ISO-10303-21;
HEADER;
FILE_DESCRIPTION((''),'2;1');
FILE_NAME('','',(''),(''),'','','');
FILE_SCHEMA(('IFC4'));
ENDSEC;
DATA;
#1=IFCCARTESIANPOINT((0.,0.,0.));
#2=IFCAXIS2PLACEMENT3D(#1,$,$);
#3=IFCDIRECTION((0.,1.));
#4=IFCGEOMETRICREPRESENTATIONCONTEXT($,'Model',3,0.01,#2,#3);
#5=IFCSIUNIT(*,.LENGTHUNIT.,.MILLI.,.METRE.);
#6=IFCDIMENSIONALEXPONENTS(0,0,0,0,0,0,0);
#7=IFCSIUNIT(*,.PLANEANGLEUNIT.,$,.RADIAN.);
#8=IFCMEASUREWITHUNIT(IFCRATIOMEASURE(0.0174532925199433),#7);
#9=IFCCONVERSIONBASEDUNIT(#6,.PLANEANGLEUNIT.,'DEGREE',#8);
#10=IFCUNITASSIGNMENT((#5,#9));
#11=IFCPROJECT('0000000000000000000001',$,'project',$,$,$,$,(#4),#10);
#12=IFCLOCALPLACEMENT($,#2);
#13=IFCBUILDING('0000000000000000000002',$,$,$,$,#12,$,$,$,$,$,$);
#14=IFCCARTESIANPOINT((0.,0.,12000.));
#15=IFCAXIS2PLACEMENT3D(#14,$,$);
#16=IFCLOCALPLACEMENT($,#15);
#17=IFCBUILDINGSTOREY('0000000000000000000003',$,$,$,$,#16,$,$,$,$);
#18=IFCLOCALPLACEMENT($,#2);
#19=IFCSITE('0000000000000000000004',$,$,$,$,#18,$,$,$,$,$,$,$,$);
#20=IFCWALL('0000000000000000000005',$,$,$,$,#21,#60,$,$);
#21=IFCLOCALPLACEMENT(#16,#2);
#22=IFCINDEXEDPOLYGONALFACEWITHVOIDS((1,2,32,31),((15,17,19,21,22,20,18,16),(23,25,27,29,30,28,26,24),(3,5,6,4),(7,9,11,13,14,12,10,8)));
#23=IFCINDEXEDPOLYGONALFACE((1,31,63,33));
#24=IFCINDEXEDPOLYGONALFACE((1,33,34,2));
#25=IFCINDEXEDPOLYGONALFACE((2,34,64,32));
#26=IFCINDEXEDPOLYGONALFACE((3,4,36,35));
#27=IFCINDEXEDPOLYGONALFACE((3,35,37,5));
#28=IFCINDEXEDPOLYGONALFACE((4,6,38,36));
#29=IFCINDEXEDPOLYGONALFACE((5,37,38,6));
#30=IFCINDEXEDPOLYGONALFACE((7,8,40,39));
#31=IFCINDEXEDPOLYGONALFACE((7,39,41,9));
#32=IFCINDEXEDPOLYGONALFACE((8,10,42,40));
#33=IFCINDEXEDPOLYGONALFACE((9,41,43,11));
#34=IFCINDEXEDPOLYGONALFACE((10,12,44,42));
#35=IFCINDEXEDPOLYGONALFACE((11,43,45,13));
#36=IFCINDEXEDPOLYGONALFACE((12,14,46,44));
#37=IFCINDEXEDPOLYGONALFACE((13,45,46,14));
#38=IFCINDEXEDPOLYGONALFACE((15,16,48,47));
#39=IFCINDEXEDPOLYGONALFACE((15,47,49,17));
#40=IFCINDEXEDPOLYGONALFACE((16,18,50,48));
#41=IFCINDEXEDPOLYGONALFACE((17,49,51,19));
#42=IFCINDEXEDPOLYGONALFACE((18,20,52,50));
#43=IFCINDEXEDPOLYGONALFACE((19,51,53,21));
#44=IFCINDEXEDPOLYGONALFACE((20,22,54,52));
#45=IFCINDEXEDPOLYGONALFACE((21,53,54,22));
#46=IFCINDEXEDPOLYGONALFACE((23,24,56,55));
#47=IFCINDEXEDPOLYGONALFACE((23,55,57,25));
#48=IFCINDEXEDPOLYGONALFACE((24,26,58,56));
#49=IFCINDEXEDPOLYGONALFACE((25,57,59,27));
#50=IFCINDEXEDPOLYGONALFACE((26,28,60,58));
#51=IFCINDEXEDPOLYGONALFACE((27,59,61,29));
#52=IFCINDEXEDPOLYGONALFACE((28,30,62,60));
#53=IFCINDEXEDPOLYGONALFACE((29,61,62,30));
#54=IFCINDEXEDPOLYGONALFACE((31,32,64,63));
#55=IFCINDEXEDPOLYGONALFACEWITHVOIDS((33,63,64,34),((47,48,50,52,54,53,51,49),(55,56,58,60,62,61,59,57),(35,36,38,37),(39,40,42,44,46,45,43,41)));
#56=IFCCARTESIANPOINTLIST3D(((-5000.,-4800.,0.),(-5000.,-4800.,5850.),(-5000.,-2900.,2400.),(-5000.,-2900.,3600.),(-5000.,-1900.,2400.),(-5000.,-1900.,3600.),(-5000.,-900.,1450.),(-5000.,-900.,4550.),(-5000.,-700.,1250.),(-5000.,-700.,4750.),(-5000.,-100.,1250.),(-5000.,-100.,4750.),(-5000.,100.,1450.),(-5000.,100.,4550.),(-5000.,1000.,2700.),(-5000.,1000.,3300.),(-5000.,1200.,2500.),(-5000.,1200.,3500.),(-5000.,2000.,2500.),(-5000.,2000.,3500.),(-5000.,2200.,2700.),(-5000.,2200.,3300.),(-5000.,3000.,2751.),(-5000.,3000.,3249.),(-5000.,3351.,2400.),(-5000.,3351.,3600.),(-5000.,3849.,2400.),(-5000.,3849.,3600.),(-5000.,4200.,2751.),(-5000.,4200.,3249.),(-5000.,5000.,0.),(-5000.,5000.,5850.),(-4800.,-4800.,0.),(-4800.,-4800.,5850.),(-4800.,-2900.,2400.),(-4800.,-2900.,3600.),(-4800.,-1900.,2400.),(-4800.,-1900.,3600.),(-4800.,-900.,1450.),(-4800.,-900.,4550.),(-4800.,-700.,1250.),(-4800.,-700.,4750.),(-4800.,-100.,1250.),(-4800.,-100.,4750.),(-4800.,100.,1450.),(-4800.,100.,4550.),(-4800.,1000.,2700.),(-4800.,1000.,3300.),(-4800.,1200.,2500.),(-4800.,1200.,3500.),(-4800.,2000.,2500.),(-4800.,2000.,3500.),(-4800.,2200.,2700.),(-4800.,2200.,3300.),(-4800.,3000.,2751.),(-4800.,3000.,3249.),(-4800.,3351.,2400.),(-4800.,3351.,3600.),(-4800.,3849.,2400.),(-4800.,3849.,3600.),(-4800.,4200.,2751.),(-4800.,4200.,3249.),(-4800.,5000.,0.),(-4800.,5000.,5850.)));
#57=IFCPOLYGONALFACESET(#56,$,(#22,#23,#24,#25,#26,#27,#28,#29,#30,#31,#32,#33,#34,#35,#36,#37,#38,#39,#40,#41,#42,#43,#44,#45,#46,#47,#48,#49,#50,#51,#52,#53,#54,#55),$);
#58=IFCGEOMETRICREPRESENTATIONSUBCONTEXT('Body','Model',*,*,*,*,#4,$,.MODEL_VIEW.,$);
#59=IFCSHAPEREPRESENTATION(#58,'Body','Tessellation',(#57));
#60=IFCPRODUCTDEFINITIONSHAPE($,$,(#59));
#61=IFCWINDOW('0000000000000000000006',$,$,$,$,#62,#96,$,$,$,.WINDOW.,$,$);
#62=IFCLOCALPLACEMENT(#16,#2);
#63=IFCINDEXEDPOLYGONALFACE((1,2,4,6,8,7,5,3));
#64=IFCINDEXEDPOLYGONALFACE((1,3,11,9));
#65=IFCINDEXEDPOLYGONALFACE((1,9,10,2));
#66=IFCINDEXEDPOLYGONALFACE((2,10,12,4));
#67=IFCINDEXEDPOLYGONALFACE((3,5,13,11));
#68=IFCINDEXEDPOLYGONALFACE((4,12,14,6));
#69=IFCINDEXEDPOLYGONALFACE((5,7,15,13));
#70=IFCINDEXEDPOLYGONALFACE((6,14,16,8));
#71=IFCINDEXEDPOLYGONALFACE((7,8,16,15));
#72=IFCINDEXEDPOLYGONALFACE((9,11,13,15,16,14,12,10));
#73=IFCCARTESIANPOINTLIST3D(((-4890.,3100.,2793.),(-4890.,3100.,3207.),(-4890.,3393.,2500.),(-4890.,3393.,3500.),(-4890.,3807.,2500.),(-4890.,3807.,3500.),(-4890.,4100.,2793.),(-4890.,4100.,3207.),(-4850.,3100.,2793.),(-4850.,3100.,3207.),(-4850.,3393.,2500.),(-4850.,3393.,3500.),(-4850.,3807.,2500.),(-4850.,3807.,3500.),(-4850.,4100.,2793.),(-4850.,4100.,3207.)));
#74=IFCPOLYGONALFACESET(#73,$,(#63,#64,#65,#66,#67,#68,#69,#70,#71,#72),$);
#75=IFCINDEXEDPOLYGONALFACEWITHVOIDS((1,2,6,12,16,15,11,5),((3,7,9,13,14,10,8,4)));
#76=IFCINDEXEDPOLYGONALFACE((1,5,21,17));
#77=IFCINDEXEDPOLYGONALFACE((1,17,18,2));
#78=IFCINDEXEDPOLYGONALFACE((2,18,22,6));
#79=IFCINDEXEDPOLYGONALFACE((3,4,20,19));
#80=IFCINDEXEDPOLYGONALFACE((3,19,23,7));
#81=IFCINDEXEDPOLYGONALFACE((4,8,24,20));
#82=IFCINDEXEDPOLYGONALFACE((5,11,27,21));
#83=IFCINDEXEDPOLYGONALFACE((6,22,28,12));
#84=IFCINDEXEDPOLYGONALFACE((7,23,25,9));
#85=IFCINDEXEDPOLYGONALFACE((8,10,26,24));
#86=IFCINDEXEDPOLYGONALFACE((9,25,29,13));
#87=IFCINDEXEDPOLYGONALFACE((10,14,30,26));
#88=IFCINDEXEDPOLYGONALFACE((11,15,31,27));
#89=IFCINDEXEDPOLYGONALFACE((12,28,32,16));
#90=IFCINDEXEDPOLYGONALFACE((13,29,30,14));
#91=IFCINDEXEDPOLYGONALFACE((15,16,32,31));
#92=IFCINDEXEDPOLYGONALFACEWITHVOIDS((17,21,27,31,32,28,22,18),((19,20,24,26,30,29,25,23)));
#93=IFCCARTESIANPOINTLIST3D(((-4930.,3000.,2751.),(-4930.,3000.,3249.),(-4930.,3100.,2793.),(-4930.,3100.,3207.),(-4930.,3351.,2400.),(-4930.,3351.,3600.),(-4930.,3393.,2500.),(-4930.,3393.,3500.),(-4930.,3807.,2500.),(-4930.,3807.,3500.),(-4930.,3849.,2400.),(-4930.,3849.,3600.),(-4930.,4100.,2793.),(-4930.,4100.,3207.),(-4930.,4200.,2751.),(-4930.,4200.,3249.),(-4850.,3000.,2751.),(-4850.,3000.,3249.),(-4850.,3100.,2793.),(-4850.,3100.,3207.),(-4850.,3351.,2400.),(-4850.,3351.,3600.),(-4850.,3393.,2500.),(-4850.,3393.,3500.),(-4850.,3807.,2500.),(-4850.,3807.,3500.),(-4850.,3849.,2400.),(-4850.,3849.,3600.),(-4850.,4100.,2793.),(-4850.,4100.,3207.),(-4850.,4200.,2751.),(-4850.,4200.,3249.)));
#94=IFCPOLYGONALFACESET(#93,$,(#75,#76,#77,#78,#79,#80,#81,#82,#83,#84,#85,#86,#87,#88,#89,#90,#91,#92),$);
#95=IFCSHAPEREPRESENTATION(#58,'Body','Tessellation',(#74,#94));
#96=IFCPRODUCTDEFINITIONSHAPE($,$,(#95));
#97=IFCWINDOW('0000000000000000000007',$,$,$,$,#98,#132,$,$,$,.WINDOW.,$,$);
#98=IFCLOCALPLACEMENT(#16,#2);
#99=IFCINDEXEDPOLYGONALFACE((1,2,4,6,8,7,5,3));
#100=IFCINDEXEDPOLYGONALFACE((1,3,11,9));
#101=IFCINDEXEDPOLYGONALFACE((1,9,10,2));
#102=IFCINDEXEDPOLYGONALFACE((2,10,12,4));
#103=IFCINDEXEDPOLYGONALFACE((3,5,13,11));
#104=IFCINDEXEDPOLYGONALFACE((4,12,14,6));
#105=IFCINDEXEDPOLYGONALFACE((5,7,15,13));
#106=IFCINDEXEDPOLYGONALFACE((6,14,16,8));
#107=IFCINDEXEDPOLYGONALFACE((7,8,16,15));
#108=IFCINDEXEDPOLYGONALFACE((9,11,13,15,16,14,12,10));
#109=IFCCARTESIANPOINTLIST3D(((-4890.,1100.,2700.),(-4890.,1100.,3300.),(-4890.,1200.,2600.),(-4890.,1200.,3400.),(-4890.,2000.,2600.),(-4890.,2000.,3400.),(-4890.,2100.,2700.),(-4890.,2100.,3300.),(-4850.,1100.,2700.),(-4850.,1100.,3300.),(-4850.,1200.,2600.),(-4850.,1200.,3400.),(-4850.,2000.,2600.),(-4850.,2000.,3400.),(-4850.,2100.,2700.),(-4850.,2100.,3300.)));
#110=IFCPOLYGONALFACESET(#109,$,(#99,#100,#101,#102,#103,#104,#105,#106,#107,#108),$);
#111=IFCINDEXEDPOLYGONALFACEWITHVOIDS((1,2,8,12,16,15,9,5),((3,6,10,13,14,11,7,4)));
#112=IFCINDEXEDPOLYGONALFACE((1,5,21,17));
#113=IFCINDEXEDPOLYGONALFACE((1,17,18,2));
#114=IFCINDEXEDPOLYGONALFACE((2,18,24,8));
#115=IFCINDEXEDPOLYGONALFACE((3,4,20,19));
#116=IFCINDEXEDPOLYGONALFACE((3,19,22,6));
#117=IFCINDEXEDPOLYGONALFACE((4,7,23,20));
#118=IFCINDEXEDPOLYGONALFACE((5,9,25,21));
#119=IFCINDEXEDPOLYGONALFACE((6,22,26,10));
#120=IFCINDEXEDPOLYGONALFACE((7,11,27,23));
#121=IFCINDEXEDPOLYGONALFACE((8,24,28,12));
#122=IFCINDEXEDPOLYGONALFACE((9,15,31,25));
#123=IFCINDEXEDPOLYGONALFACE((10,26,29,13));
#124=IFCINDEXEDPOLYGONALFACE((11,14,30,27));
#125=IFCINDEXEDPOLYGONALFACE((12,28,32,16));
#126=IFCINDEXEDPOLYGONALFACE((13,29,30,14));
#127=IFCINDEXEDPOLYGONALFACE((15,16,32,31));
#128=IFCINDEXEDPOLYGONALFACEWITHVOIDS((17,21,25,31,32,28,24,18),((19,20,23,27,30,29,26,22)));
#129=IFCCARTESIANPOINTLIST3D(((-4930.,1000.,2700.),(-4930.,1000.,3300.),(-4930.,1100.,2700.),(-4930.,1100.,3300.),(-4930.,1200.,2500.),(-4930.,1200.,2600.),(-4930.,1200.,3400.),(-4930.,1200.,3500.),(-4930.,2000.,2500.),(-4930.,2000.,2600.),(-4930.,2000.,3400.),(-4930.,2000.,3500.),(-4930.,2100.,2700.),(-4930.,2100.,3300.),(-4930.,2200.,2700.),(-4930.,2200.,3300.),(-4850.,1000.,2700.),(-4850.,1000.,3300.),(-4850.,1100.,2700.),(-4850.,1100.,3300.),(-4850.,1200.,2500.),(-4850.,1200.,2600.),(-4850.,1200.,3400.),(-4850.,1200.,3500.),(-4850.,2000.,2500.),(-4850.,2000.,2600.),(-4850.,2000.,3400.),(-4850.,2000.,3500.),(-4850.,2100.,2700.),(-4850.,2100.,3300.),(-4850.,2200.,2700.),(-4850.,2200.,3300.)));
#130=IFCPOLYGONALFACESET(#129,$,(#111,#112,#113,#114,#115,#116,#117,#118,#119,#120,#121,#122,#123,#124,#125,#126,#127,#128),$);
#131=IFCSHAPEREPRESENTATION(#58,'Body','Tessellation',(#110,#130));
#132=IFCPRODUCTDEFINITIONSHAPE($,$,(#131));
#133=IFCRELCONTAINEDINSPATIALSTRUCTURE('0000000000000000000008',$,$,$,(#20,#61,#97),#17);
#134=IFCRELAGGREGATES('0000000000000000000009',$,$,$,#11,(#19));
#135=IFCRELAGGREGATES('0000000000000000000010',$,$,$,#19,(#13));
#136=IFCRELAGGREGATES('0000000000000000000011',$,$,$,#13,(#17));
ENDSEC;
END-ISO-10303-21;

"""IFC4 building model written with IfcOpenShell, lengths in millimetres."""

from ifc_helpers import new_model, entity, si_unit, converted_unit, direction, frame, origin, origin_2d, place, context, subcontext, project, spatial, polyline, rectangle, outline, extrude, element, save


model = new_model("IFC4")

# Units and contexts
model_context = context("Model", 3, precision=0.01, world=origin(), true_north=direction((0.0, 1.0)))
body_context = subcontext(model_context, "Body", "Model", "MODEL_VIEW")
ifc_project = project(units=[si_unit("LENGTHUNIT", "METRE", prefix="MILLI"), converted_unit("PLANEANGLEUNIT", "DEGREE", entity("IfcRatioMeasure", 0.0174532925199433), si_unit("PLANEANGLEUNIT", "RADIAN"), dimensions=[0, 0, 0, 0, 0, 0, 0])], contexts=[model_context])

# Site, building, storey
site_placement = place(None, origin())
site = spatial("IfcSite", under=ifc_project, at=site_placement)
building_placement = place(None, origin())
building = spatial("IfcBuilding", under=site, at=building_placement)
storey_placement = place(None, frame((0.0, 0.0, 12000.0)))
storey = spatial("IfcBuildingStorey", under=building, at=storey_placement)

# Shared definitions
cartesian_point_1 = entity("IfcCartesianPoint", [-500.0, -207.0])
shared_polyline_1 = entity("IfcPolyline", [cartesian_point_1, entity("IfcCartesianPoint", [-500.0, 207.0]), entity("IfcCartesianPoint", [-207.0, 500.0]), entity("IfcCartesianPoint", [207.0, 500.0]), entity("IfcCartesianPoint", [500.0, 207.0]), entity("IfcCartesianPoint", [500.0, -207.0]), entity("IfcCartesianPoint", [207.0, -500.0]), entity("IfcCartesianPoint", [-207.0, -500.0]), cartesian_point_1])
cartesian_point_2 = entity("IfcCartesianPoint", [-500.0, -300.0])
shared_polyline_2 = entity("IfcPolyline", [cartesian_point_2, entity("IfcCartesianPoint", [-500.0, 300.0]), entity("IfcCartesianPoint", [-400.0, 400.0]), entity("IfcCartesianPoint", [400.0, 400.0]), entity("IfcCartesianPoint", [500.0, 300.0]), entity("IfcCartesianPoint", [500.0, -300.0]), entity("IfcCartesianPoint", [400.0, -400.0]), entity("IfcCartesianPoint", [-400.0, -400.0]), cartesian_point_2])

# Wall, openings
wall_1_placement = place(storey_placement, frame((-4900.0, 100.0, 0.0), z_axis=(0.0, 0.0, 1.0), x_axis=(0.0, -1.0, 0.0)))
wall_1 = element("IfcWall", 1, at=wall_1_placement, inside=storey, context=body_context, shape_type="SweptSolid", body=[
    extrude(rectangle(XDim=9800.0, YDim=200.0, at=origin_2d()), origin(), (0.0, 0.0, 1.0), 5850.0),
])
window_1_placement = place(wall_1_placement, frame((-3500.0, 50.0, 3000.0)))
opening_1_placement = place(window_1_placement, frame((0.0, 50.0, 0.0)))
element("IfcOpeningElement", 2, at=opening_1_placement, cuts=wall_1, context=body_context, shape_type="SweptSolid", body=[
    extrude(outline(polyline([(-600.0, -249.0), (-600.0, 249.0), (-249.0, 600.0), (249.0, 600.0), (600.0, 249.0), (600.0, -249.0), (249.0, -600.0), (-249.0, -600.0), (-600.0, -249.0)])), frame((0.0, 0.0, 0.0), z_axis=(0.0, -1.0, 0.0), x_axis=(1.0, 0.0, 0.0)), (0.0, 0.0, 1.0), 200.0),
])
window_2_placement = place(wall_1_placement, frame((-1500.0, 50.0, 3000.0)))
opening_2_placement = place(window_2_placement, frame((0.0, 50.0, 0.0)))
element("IfcOpeningElement", 3, at=opening_2_placement, cuts=wall_1, context=body_context, shape_type="SweptSolid", body=[
    extrude(outline(polyline([(-600.0, -300.0), (-600.0, 300.0), (-400.0, 500.0), (400.0, 500.0), (600.0, 300.0), (600.0, -300.0), (400.0, -500.0), (-400.0, -500.0), (-600.0, -300.0)])), frame((0.0, 0.0, 0.0), z_axis=(0.0, -1.0, 0.0), x_axis=(1.0, 0.0, 0.0)), (0.0, 0.0, 1.0), 200.0),
])
window_3_placement = place(wall_1_placement, frame((500.0, 50.0, 3000.0)))
opening_3_placement = place(window_3_placement, frame((0.0, 50.0, 0.0)))
element("IfcOpeningElement", 4, at=opening_3_placement, cuts=wall_1, context=body_context, shape_type="SweptSolid", body=[
    extrude(outline(polyline([(-500.0, -1550.0), (-500.0, 1550.0), (-300.0, 1750.0), (300.0, 1750.0), (500.0, 1550.0), (500.0, -1550.0), (300.0, -1750.0), (-300.0, -1750.0), (-500.0, -1550.0)])), frame((0.0, 0.0, 0.0), z_axis=(0.0, -1.0, 0.0), x_axis=(1.0, 0.0, 0.0)), (0.0, 0.0, 1.0), 200.0),
])
window_4_placement = place(wall_1_placement, frame((2500.0, 50.0, 3000.0)))
opening_4_placement = place(window_4_placement, frame((0.0, 50.0, 0.0)))
element("IfcOpeningElement", 5, at=opening_4_placement, cuts=wall_1, context=body_context, shape_type="SweptSolid", body=[
    extrude(outline(polyline([(-500.0, -600.0), (-500.0, 600.0), (-500.0, 600.0), (500.0, 600.0), (500.0, 600.0), (500.0, -600.0), (500.0, -600.0), (-500.0, -600.0), (-500.0, -600.0)])), frame((0.0, 0.0, 0.0), z_axis=(0.0, -1.0, 0.0), x_axis=(1.0, 0.0, 0.0)), (0.0, 0.0, 1.0), 200.0),
])

# Windows
cartesian_point_3 = entity("IfcCartesianPoint", [-600.0, -249.0])
element("IfcWindow", 6, at=window_1_placement, inside=storey, PredefinedType="WINDOW", context=body_context, shape_type="SweptSolid", body=[
    entity("IfcExtrudedAreaSolid", entity("IfcArbitraryClosedProfileDef", "AREA", None, shared_polyline_1), entity("IfcAxis2Placement3D", entity("IfcCartesianPoint", [0.0, 0.0, 0.0]), entity("IfcDirection", [0.0, -1.0, 0.0]), entity("IfcDirection", [1.0, 0.0, 0.0])), entity("IfcDirection", [0.0, 0.0, 1.0]), 40.0),
    entity("IfcExtrudedAreaSolid", entity("IfcArbitraryProfileDefWithVoids", "AREA", None, entity("IfcPolyline", [cartesian_point_3, entity("IfcCartesianPoint", [-600.0, 249.0]), entity("IfcCartesianPoint", [-249.0, 600.0]), entity("IfcCartesianPoint", [249.0, 600.0]), entity("IfcCartesianPoint", [600.0, 249.0]), entity("IfcCartesianPoint", [600.0, -249.0]), entity("IfcCartesianPoint", [249.0, -600.0]), entity("IfcCartesianPoint", [-249.0, -600.0]), cartesian_point_3]), [shared_polyline_1]), entity("IfcAxis2Placement3D", entity("IfcCartesianPoint", [0.0, 0.0, 0.0]), entity("IfcDirection", [0.0, -1.0, 0.0]), entity("IfcDirection", [1.0, 0.0, 0.0])), entity("IfcDirection", [0.0, 0.0, 1.0]), 80.0),
])
cartesian_point_4 = entity("IfcCartesianPoint", [-600.0, -300.0])
element("IfcWindow", 7, at=window_2_placement, inside=storey, PredefinedType="WINDOW", context=body_context, shape_type="SweptSolid", body=[
    entity("IfcExtrudedAreaSolid", entity("IfcArbitraryClosedProfileDef", "AREA", None, shared_polyline_2), entity("IfcAxis2Placement3D", entity("IfcCartesianPoint", [0.0, 0.0, 0.0]), entity("IfcDirection", [0.0, -1.0, 0.0]), entity("IfcDirection", [1.0, 0.0, 0.0])), entity("IfcDirection", [0.0, 0.0, 1.0]), 40.0),
    entity("IfcExtrudedAreaSolid", entity("IfcArbitraryProfileDefWithVoids", "AREA", None, entity("IfcPolyline", [cartesian_point_4, entity("IfcCartesianPoint", [-600.0, 300.0]), entity("IfcCartesianPoint", [-400.0, 500.0]), entity("IfcCartesianPoint", [400.0, 500.0]), entity("IfcCartesianPoint", [600.0, 300.0]), entity("IfcCartesianPoint", [600.0, -300.0]), entity("IfcCartesianPoint", [400.0, -500.0]), entity("IfcCartesianPoint", [-400.0, -500.0]), cartesian_point_4]), [shared_polyline_2]), entity("IfcAxis2Placement3D", entity("IfcCartesianPoint", [0.0, 0.0, 0.0]), entity("IfcDirection", [0.0, -1.0, 0.0]), entity("IfcDirection", [1.0, 0.0, 0.0])), entity("IfcDirection", [0.0, 0.0, 1.0]), 80.0),
])

save(model, "model.ifc")
